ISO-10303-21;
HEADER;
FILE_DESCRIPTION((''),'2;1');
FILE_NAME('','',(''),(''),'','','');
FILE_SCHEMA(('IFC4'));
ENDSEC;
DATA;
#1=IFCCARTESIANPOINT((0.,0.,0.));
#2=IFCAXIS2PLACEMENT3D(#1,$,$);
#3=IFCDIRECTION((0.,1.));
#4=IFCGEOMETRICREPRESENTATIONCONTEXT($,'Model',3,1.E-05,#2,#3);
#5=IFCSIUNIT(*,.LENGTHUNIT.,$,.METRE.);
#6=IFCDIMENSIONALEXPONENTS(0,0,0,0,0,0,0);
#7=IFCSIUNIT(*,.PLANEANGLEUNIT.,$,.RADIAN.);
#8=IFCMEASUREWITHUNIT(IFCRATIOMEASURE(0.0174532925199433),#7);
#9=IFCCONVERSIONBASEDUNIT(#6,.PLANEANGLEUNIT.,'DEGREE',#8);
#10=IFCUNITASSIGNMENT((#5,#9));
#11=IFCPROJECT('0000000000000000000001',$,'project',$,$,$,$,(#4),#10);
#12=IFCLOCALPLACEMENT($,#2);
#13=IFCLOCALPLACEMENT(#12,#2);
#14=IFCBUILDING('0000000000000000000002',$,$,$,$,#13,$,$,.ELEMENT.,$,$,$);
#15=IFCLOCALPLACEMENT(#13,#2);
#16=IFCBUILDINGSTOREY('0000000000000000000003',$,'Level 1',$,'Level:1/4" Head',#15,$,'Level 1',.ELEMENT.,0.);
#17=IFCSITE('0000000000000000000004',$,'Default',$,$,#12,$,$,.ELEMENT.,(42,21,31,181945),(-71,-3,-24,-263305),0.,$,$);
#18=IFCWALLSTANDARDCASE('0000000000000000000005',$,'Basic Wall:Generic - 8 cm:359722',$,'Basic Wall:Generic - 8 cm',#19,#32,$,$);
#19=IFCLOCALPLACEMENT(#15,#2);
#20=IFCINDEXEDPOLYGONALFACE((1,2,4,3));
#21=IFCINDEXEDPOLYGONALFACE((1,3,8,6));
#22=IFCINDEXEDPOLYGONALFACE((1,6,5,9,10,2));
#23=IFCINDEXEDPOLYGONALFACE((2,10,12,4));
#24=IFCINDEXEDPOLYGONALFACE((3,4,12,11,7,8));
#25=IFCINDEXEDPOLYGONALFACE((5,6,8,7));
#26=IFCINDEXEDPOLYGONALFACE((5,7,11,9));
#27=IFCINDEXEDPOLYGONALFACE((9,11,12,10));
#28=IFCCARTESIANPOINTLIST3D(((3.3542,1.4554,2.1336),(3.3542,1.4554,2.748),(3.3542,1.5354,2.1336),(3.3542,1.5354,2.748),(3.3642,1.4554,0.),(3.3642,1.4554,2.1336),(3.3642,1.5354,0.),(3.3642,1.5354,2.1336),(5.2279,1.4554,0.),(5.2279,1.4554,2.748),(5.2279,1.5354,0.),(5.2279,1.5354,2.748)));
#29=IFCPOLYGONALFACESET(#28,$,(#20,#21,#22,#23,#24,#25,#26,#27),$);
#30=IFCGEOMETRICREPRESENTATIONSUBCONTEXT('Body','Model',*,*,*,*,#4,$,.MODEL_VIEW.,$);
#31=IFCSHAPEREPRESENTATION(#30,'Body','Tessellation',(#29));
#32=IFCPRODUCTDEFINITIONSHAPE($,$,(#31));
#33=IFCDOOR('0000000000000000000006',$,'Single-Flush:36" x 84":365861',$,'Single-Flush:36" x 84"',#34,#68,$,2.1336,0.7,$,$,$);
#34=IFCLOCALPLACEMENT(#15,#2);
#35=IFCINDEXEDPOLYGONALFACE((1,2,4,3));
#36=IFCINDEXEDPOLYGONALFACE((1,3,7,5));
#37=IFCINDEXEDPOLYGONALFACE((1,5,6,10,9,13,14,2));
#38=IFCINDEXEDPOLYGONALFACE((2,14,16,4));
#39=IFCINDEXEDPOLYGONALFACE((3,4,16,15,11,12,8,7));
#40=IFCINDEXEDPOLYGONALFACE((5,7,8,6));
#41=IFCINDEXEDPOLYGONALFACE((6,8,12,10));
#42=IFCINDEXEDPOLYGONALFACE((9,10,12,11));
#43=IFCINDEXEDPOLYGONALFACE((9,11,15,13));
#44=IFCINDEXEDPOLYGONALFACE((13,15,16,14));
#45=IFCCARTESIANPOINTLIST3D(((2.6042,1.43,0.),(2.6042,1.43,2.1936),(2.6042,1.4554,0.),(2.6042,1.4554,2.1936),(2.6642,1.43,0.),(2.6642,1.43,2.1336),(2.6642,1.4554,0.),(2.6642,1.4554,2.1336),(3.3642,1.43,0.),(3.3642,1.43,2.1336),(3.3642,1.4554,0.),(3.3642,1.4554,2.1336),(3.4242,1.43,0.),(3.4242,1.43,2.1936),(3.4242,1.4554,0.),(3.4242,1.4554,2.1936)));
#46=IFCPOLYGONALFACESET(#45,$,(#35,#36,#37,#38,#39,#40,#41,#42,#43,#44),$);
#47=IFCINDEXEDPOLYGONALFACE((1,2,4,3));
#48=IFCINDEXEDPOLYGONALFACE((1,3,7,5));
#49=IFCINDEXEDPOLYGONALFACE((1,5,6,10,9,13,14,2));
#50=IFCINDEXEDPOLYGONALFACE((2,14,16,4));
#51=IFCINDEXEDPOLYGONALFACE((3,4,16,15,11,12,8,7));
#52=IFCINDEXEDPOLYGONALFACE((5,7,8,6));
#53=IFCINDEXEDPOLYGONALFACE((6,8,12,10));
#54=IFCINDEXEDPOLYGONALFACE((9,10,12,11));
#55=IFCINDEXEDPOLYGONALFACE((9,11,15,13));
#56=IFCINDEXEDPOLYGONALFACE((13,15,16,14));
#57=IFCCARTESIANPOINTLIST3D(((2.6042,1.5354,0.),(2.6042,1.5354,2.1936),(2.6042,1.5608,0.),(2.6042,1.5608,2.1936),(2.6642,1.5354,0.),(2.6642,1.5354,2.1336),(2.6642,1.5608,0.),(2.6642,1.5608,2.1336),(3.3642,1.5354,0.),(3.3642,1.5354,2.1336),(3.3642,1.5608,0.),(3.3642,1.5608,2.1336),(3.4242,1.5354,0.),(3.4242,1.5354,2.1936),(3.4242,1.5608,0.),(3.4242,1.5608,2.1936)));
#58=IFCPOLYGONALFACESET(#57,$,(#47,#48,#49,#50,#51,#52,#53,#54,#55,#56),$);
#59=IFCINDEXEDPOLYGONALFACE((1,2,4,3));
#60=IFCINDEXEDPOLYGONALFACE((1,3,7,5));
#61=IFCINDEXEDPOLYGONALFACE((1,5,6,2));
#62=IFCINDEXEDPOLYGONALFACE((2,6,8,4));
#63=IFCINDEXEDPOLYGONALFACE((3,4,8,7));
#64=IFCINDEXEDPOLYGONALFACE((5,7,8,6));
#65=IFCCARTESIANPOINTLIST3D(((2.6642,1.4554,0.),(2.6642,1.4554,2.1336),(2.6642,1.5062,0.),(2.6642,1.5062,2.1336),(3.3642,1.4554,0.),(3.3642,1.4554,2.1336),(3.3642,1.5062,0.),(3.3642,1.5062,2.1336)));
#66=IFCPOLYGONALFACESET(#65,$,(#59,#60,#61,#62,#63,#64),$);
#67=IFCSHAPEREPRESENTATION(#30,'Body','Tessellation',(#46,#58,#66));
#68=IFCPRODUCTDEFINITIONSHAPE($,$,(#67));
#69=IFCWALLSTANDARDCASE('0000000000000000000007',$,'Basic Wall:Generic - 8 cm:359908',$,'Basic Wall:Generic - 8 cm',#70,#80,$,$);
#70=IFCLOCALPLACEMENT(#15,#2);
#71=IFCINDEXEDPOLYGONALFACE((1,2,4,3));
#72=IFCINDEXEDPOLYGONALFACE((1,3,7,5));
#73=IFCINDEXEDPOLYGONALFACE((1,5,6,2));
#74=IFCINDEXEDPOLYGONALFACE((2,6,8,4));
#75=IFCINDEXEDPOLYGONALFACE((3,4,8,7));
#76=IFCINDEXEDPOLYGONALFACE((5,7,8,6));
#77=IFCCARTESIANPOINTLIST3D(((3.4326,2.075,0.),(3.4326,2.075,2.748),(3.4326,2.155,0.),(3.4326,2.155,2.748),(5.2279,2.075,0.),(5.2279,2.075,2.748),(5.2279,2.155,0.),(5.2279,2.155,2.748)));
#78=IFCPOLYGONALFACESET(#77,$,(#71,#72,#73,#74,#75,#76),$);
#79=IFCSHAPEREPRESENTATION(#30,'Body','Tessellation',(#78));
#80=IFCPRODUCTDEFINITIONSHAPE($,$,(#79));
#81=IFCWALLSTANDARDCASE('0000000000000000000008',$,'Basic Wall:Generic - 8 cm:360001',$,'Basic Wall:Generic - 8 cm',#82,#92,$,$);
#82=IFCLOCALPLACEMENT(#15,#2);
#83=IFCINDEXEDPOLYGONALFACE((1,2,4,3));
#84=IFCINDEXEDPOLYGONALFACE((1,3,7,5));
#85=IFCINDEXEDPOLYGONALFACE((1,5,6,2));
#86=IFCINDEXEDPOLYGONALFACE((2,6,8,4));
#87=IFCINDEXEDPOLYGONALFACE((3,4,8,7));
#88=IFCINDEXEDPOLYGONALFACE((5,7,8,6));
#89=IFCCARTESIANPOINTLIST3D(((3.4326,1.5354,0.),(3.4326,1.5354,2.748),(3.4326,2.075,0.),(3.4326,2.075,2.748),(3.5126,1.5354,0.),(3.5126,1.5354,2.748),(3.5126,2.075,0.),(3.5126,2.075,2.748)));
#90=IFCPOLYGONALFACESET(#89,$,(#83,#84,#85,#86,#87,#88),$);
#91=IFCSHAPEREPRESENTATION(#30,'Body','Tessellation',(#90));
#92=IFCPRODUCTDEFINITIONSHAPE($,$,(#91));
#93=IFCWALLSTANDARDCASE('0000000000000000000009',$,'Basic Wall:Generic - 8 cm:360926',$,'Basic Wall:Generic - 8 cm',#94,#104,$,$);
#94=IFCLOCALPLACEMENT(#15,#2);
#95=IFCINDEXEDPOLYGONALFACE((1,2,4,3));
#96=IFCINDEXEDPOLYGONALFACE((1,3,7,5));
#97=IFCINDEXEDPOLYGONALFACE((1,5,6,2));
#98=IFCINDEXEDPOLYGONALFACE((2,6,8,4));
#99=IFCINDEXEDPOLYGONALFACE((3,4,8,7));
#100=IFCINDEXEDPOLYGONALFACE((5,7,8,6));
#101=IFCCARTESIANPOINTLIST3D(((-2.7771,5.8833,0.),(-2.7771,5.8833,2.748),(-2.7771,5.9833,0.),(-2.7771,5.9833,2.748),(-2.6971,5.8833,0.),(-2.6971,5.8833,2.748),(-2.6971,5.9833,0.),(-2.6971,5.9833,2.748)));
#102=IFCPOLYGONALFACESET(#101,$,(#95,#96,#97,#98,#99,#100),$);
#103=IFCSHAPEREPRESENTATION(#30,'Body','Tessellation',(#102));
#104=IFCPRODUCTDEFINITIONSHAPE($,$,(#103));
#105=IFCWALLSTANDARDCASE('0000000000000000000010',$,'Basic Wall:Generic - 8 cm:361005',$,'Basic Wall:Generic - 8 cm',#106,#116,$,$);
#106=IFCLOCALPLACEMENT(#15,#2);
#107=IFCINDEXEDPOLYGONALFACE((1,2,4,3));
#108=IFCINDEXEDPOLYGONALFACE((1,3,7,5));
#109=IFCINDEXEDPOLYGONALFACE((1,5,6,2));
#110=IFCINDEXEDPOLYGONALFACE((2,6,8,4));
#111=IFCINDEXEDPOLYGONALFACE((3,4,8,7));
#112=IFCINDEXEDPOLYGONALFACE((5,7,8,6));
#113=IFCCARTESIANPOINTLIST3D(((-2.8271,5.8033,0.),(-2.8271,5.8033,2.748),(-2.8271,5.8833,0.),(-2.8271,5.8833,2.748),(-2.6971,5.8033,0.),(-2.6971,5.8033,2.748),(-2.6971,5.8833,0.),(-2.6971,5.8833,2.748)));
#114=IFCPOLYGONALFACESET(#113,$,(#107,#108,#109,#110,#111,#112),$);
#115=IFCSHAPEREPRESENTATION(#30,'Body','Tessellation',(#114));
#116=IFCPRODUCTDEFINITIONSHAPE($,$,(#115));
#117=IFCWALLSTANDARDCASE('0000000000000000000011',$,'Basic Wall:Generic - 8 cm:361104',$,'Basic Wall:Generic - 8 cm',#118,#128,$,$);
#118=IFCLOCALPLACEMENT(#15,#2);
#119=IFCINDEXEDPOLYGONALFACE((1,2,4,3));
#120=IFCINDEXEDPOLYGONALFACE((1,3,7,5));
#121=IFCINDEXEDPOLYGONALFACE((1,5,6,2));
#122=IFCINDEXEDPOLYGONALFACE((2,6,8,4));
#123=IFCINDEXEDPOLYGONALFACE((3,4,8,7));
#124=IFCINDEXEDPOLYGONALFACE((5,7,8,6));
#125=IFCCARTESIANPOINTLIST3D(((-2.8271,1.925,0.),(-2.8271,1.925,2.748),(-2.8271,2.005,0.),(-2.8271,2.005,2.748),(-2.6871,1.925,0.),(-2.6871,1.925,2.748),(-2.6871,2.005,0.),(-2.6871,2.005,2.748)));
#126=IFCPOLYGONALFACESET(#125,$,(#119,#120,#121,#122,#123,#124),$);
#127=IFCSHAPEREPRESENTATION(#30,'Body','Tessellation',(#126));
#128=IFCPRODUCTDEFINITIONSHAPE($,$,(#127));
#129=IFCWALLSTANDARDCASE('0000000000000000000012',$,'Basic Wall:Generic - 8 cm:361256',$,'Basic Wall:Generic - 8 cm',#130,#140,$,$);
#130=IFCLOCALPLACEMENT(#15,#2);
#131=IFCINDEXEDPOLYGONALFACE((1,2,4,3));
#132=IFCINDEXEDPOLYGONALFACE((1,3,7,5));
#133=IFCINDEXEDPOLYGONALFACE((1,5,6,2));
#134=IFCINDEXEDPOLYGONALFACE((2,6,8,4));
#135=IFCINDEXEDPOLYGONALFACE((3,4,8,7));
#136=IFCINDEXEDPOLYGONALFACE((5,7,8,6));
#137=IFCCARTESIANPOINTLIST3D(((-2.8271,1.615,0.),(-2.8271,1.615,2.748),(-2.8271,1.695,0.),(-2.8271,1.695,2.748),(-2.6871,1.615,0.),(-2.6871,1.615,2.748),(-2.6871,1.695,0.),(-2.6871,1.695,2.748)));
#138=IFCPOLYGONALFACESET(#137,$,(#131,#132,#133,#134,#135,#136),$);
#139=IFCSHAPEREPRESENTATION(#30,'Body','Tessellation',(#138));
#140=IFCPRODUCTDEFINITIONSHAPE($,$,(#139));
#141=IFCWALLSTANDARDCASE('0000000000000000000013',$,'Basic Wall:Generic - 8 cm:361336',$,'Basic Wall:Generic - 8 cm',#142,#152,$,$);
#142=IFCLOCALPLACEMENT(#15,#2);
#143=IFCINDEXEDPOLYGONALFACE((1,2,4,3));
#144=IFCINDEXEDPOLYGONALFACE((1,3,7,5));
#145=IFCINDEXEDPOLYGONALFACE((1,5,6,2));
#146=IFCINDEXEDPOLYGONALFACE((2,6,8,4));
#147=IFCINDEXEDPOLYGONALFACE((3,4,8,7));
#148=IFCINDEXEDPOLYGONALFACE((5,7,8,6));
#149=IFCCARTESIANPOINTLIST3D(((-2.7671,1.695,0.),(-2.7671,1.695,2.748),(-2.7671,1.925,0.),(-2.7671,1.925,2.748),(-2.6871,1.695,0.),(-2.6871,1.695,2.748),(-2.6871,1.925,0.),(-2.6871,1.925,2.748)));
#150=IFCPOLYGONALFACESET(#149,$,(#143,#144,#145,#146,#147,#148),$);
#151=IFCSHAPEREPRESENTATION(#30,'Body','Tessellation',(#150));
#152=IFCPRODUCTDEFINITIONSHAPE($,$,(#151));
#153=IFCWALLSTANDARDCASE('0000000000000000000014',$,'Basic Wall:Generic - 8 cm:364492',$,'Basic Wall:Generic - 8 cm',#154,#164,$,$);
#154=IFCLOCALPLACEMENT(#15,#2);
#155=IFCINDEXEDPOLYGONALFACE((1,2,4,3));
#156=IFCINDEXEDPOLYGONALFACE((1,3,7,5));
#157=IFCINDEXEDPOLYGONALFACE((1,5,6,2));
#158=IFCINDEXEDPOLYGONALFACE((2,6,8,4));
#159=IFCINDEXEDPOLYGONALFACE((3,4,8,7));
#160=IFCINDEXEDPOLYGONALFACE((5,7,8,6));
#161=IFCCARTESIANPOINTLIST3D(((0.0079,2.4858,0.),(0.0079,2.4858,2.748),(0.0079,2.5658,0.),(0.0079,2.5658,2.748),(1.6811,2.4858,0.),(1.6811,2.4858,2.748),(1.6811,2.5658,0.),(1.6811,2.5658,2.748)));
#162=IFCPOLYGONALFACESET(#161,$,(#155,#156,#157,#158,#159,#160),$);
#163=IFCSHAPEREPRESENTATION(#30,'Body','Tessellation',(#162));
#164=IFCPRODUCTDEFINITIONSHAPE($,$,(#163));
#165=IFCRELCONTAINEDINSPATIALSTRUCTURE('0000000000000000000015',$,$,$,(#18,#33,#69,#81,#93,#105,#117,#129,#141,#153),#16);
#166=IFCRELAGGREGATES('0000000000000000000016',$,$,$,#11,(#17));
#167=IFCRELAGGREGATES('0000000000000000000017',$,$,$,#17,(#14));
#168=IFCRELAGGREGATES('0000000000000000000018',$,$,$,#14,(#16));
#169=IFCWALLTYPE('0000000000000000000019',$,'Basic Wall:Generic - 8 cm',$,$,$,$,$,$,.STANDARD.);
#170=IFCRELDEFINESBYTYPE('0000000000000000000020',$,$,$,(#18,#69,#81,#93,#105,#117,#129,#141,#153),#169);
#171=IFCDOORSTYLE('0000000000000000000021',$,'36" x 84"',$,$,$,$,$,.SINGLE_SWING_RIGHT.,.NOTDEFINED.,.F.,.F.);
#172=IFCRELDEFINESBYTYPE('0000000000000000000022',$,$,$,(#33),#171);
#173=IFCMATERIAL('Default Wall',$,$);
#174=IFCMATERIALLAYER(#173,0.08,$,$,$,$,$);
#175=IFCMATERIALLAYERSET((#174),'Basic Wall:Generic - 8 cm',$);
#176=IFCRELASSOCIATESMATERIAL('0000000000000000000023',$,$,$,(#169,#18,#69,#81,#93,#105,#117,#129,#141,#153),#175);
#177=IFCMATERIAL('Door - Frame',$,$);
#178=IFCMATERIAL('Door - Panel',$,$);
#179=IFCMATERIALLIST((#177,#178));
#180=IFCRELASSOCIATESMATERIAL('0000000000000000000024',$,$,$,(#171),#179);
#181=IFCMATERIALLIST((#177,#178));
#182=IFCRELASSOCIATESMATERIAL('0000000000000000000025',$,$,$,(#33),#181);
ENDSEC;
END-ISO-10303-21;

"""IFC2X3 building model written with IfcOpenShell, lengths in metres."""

from ifc_helpers import new_model, entity, si_unit, converted_unit, direction, frame, frame_2d, origin, origin_2d_with_axis, place, context, subcontext, project, spatial, polyline, rectangle, outline, extrude, source, transform, mapped, material, material_list, layer, layer_set, layer_usage, type_object, type_shapes, element, fill, save


model = new_model("IFC2X3")

# Units and contexts
model_context = context("Model", 3, precision=1e-05, world=origin(), true_north=direction((0.0, 1.0)))
body_context = subcontext(model_context, "Body", "Model", "MODEL_VIEW")
ifc_project = project(units=[si_unit("LENGTHUNIT", "METRE"), converted_unit("PLANEANGLEUNIT", "DEGREE", entity("IfcRatioMeasure", 0.0174532925199433), si_unit("PLANEANGLEUNIT", "RADIAN"), dimensions=[0, 0, 0, 0, 0, 0, 0])], contexts=[model_context])

# Site, building, storey
site_placement = place(None, origin())
site = spatial("IfcSite", under=ifc_project, at=site_placement, Name="Default", CompositionType="ELEMENT", RefLatitude=(42, 21, 31, 181945), RefLongitude=(-71, -3, -24, -263305), RefElevation=0.0)
building_placement = place(site_placement, origin())
building = spatial("IfcBuilding", under=site, at=building_placement, CompositionType="ELEMENT")
storey_placement = place(building_placement, origin())
storey = spatial("IfcBuildingStorey", under=building, at=storey_placement, Name="Level 1", ObjectType="Level:1/4\" Head", LongName="Level 1", CompositionType="ELEMENT", Elevation=0.0)

# Shared definitions
ifc_material_1 = material(Name="Default Wall")
ifc_layer_1 = layer(ifc_material_1, 0.08)
ifc_layer_set_1 = layer_set([ifc_layer_1], Name="Basic Wall:Generic - 8 cm")
wall_type = type_object("IfcWallType", Name="Basic Wall:Generic - 8 cm", PredefinedType="STANDARD", material=ifc_layer_set_1)

# Shared definitions
ifc_material_2 = material(Name="Door - Frame")
ifc_material_3 = material(Name="Door - Panel")
ifc_material_list_1 = material_list([ifc_material_2, ifc_material_3])
door_style = type_object("IfcDoorStyle", Name="36\" x 84\"", ConstructionType="NOTDEFINED", OperationType="SINGLE_SWING_RIGHT", ParameterTakesPrecedence=False, Sizeable=False, material=ifc_material_list_1)
shared_shape = source(origin(), body_context, "Body", "SweptSolid", [
    extrude(outline(polyline([(-0.41, -1.1118), (0.41, -1.1118), (0.41, 1.0818), (0.35, 1.0818), (0.35, -1.0518), (-0.35, -1.0518), (-0.35, 1.0818), (-0.41, 1.0818), (-0.41, -1.1118)])), frame((0.35, 0.08, 1.0818), z_axis=(0.0, 1.0, 0.0), x_axis=(1.0, 0.0, 0.0)), (0.0, 0.0, 1.0), 0.0254),
    extrude(outline(polyline([(-1.1118, -0.41), (1.0818, -0.41), (1.0818, -0.35), (-1.0518, -0.35), (-1.0518, 0.35), (1.0818, 0.35), (1.0818, 0.41), (-1.1118, 0.41), (-1.1118, -0.41)])), frame((0.35, -0.0254, 1.0818), z_axis=(0.0, 1.0, 0.0), x_axis=(0.0, 0.0, -1.0)), (0.0, 0.0, 1.0), 0.0254),
    extrude(rectangle(XDim=0.0508, YDim=0.7, at=origin_2d_with_axis()), frame((0.35, 0.0546, 0.0), z_axis=(0.0, 0.0, 1.0), x_axis=(0.0, 1.0, 0.0)), (0.0, 0.0, 1.0), 2.1336),
])
type_shapes(door_style, [shared_shape])

# Wall, opening, door
ifc_layer_usage_1 = layer_usage(ifc_layer_set_1, "AXIS2", "NEGATIVE", 0.04)
wall_1_placement = place(storey_placement, frame((3.3542, 1.4954, 0.0)))
wall_1 = element("IfcWallStandardCase", 1, at=wall_1_placement, inside=storey, type_object=wall_type, material=ifc_layer_usage_1, Name="Basic Wall:Generic - 8 cm:359722", ObjectType="Basic Wall:Generic - 8 cm", context=body_context, shape_type="SweptSolid", body=[
    extrude(rectangle(XDim=1.8737, YDim=0.08, at=frame_2d((0.9368, 0.0), x_axis=(-1.0, 0.0))), origin(), (0.0, 0.0, 1.0), 2.748),
])
opening_1_placement = place(wall_1_placement, frame((0.01, 0.04, 0.0)))
opening_1 = element("IfcOpeningElement", 2, at=opening_1_placement, cuts=wall_1, ObjectType="Opening", context=body_context, shape_type="SweptSolid", body=[
    extrude(rectangle(XDim=0.7, YDim=2.1336, at=frame_2d((1.0668, 0.35), x_axis=(0.0, 1.0))), frame((0.0, 0.0, 0.0), z_axis=(0.0, -1.0, 0.0), x_axis=(0.0, 0.0, 1.0)), (0.0, 0.0, 1.0), 0.08),
])
ifc_material_list_2 = material_list([ifc_material_2, ifc_material_3])
door_1_placement = place(opening_1_placement, frame((0.0, 0.0, 0.0), z_axis=(0.0, 0.0, 1.0), x_axis=(-1.0, 0.0, 0.0)))
door_1 = element("IfcDoor", 3, at=door_1_placement, inside=storey, type_object=door_style, material=ifc_material_list_2, Name="Single-Flush:36\" x 84\":365861", ObjectType="Single-Flush:36\" x 84\"", OverallHeight=2.1336, OverallWidth=0.7, context=body_context, shape_type="MappedRepresentation", body=[
    mapped(shared_shape, transform((0.0, 0.0, 0.0), scale=1.0)),
])
fill(opening_1, door_1)

# Walls
ifc_layer_usage_2 = layer_usage(ifc_layer_set_1, "AXIS2", "NEGATIVE", 0.04)
wall_2_placement = place(storey_placement, frame((5.2279, 2.115, 0.0), z_axis=(0.0, 0.0, 1.0), x_axis=(-1.0, 0.0, 0.0)))
element("IfcWallStandardCase", 4, at=wall_2_placement, inside=storey, type_object=wall_type, material=ifc_layer_usage_2, Name="Basic Wall:Generic - 8 cm:359908", ObjectType="Basic Wall:Generic - 8 cm", context=body_context, shape_type="SweptSolid", body=[
    extrude(rectangle(XDim=1.7953, YDim=0.08, at=frame_2d((0.8977, 0.0), x_axis=(-1.0, 0.0))), origin(), (0.0, 0.0, 1.0), 2.748),
])
ifc_layer_usage_3 = layer_usage(ifc_layer_set_1, "AXIS2", "NEGATIVE", 0.04)
wall_3_placement = place(storey_placement, frame((3.4726, 2.075, 0.0), z_axis=(0.0, 0.0, 1.0), x_axis=(0.0, -1.0, 0.0)))
element("IfcWallStandardCase", 5, at=wall_3_placement, inside=storey, type_object=wall_type, material=ifc_layer_usage_3, Name="Basic Wall:Generic - 8 cm:360001", ObjectType="Basic Wall:Generic - 8 cm", context=body_context, shape_type="SweptSolid", body=[
    extrude(rectangle(XDim=0.5396, YDim=0.08, at=frame_2d((0.2698, 0.0), x_axis=(-1.0, 0.0))), origin(), (0.0, 0.0, 1.0), 2.748),
])
ifc_layer_usage_4 = layer_usage(ifc_layer_set_1, "AXIS2", "NEGATIVE", 0.04)
wall_4_placement = place(storey_placement, frame((-2.7371, 5.9833, 0.0), z_axis=(0.0, 0.0, 1.0), x_axis=(0.0, -1.0, 0.0)))
element("IfcWallStandardCase", 6, at=wall_4_placement, inside=storey, type_object=wall_type, material=ifc_layer_usage_4, Name="Basic Wall:Generic - 8 cm:360926", ObjectType="Basic Wall:Generic - 8 cm", context=body_context, shape_type="SweptSolid", body=[
    extrude(rectangle(XDim=0.1, YDim=0.08, at=frame_2d((0.05, 0.0), x_axis=(-1.0, 0.0))), origin(), (0.0, 0.0, 1.0), 2.748),
])
ifc_layer_usage_5 = layer_usage(ifc_layer_set_1, "AXIS2", "NEGATIVE", 0.04)
wall_5_placement = place(storey_placement, frame((-2.6971, 5.8433, 0.0), z_axis=(0.0, 0.0, 1.0), x_axis=(-1.0, 0.0, 0.0)))
element("IfcWallStandardCase", 7, at=wall_5_placement, inside=storey, type_object=wall_type, material=ifc_layer_usage_5, Name="Basic Wall:Generic - 8 cm:361005", ObjectType="Basic Wall:Generic - 8 cm", context=body_context, shape_type="SweptSolid", body=[
    extrude(rectangle(XDim=0.13, YDim=0.08, at=frame_2d((0.065, 0.0), x_axis=(-1.0, 0.0))), origin(), (0.0, 0.0, 1.0), 2.748),
])
ifc_layer_usage_6 = layer_usage(ifc_layer_set_1, "AXIS2", "NEGATIVE", 0.04)
wall_6_placement = place(storey_placement, frame((-2.8271, 1.965, 0.0)))
element("IfcWallStandardCase", 8, at=wall_6_placement, inside=storey, type_object=wall_type, material=ifc_layer_usage_6, Name="Basic Wall:Generic - 8 cm:361104", ObjectType="Basic Wall:Generic - 8 cm", context=body_context, shape_type="SweptSolid", body=[
    extrude(rectangle(XDim=0.14, YDim=0.08, at=frame_2d((0.07, 0.0), x_axis=(-1.0, 0.0))), origin(), (0.0, 0.0, 1.0), 2.748),
])
ifc_layer_usage_7 = layer_usage(ifc_layer_set_1, "AXIS2", "NEGATIVE", 0.04)
wall_7_placement = place(storey_placement, frame((-2.8271, 1.655, 0.0)))
element("IfcWallStandardCase", 9, at=wall_7_placement, inside=storey, type_object=wall_type, material=ifc_layer_usage_7, Name="Basic Wall:Generic - 8 cm:361256", ObjectType="Basic Wall:Generic - 8 cm", context=body_context, shape_type="SweptSolid", body=[
    extrude(rectangle(XDim=0.14, YDim=0.08, at=frame_2d((0.07, 0.0), x_axis=(-1.0, 0.0))), origin(), (0.0, 0.0, 1.0), 2.748),
])
ifc_layer_usage_8 = layer_usage(ifc_layer_set_1, "AXIS2", "NEGATIVE", 0.04)
wall_8_placement = place(storey_placement, frame((-2.7271, 1.695, 0.0), z_axis=(0.0, 0.0, 1.0), x_axis=(0.0, 1.0, 0.0)))
element("IfcWallStandardCase", 10, at=wall_8_placement, inside=storey, type_object=wall_type, material=ifc_layer_usage_8, Name="Basic Wall:Generic - 8 cm:361336", ObjectType="Basic Wall:Generic - 8 cm", context=body_context, shape_type="SweptSolid", body=[
    extrude(rectangle(XDim=0.23, YDim=0.08, at=frame_2d((0.115, 0.0), x_axis=(-1.0, 0.0))), origin(), (0.0, 0.0, 1.0), 2.748),
])
ifc_layer_usage_9 = layer_usage(ifc_layer_set_1, "AXIS2", "NEGATIVE", 0.04)
wall_9_placement = place(storey_placement, frame((0.0079, 2.5258, 0.0)))
element("IfcWallStandardCase", 11, at=wall_9_placement, inside=storey, type_object=wall_type, material=ifc_layer_usage_9, Name="Basic Wall:Generic - 8 cm:364492", ObjectType="Basic Wall:Generic - 8 cm", context=body_context, shape_type="SweptSolid", body=[
    extrude(rectangle(XDim=1.6732, YDim=0.08, at=frame_2d((0.8366, 0.0), x_axis=(-1.0, 0.0))), origin(), (0.0, 0.0, 1.0), 2.748),
])

save(model, "model.ifc")
